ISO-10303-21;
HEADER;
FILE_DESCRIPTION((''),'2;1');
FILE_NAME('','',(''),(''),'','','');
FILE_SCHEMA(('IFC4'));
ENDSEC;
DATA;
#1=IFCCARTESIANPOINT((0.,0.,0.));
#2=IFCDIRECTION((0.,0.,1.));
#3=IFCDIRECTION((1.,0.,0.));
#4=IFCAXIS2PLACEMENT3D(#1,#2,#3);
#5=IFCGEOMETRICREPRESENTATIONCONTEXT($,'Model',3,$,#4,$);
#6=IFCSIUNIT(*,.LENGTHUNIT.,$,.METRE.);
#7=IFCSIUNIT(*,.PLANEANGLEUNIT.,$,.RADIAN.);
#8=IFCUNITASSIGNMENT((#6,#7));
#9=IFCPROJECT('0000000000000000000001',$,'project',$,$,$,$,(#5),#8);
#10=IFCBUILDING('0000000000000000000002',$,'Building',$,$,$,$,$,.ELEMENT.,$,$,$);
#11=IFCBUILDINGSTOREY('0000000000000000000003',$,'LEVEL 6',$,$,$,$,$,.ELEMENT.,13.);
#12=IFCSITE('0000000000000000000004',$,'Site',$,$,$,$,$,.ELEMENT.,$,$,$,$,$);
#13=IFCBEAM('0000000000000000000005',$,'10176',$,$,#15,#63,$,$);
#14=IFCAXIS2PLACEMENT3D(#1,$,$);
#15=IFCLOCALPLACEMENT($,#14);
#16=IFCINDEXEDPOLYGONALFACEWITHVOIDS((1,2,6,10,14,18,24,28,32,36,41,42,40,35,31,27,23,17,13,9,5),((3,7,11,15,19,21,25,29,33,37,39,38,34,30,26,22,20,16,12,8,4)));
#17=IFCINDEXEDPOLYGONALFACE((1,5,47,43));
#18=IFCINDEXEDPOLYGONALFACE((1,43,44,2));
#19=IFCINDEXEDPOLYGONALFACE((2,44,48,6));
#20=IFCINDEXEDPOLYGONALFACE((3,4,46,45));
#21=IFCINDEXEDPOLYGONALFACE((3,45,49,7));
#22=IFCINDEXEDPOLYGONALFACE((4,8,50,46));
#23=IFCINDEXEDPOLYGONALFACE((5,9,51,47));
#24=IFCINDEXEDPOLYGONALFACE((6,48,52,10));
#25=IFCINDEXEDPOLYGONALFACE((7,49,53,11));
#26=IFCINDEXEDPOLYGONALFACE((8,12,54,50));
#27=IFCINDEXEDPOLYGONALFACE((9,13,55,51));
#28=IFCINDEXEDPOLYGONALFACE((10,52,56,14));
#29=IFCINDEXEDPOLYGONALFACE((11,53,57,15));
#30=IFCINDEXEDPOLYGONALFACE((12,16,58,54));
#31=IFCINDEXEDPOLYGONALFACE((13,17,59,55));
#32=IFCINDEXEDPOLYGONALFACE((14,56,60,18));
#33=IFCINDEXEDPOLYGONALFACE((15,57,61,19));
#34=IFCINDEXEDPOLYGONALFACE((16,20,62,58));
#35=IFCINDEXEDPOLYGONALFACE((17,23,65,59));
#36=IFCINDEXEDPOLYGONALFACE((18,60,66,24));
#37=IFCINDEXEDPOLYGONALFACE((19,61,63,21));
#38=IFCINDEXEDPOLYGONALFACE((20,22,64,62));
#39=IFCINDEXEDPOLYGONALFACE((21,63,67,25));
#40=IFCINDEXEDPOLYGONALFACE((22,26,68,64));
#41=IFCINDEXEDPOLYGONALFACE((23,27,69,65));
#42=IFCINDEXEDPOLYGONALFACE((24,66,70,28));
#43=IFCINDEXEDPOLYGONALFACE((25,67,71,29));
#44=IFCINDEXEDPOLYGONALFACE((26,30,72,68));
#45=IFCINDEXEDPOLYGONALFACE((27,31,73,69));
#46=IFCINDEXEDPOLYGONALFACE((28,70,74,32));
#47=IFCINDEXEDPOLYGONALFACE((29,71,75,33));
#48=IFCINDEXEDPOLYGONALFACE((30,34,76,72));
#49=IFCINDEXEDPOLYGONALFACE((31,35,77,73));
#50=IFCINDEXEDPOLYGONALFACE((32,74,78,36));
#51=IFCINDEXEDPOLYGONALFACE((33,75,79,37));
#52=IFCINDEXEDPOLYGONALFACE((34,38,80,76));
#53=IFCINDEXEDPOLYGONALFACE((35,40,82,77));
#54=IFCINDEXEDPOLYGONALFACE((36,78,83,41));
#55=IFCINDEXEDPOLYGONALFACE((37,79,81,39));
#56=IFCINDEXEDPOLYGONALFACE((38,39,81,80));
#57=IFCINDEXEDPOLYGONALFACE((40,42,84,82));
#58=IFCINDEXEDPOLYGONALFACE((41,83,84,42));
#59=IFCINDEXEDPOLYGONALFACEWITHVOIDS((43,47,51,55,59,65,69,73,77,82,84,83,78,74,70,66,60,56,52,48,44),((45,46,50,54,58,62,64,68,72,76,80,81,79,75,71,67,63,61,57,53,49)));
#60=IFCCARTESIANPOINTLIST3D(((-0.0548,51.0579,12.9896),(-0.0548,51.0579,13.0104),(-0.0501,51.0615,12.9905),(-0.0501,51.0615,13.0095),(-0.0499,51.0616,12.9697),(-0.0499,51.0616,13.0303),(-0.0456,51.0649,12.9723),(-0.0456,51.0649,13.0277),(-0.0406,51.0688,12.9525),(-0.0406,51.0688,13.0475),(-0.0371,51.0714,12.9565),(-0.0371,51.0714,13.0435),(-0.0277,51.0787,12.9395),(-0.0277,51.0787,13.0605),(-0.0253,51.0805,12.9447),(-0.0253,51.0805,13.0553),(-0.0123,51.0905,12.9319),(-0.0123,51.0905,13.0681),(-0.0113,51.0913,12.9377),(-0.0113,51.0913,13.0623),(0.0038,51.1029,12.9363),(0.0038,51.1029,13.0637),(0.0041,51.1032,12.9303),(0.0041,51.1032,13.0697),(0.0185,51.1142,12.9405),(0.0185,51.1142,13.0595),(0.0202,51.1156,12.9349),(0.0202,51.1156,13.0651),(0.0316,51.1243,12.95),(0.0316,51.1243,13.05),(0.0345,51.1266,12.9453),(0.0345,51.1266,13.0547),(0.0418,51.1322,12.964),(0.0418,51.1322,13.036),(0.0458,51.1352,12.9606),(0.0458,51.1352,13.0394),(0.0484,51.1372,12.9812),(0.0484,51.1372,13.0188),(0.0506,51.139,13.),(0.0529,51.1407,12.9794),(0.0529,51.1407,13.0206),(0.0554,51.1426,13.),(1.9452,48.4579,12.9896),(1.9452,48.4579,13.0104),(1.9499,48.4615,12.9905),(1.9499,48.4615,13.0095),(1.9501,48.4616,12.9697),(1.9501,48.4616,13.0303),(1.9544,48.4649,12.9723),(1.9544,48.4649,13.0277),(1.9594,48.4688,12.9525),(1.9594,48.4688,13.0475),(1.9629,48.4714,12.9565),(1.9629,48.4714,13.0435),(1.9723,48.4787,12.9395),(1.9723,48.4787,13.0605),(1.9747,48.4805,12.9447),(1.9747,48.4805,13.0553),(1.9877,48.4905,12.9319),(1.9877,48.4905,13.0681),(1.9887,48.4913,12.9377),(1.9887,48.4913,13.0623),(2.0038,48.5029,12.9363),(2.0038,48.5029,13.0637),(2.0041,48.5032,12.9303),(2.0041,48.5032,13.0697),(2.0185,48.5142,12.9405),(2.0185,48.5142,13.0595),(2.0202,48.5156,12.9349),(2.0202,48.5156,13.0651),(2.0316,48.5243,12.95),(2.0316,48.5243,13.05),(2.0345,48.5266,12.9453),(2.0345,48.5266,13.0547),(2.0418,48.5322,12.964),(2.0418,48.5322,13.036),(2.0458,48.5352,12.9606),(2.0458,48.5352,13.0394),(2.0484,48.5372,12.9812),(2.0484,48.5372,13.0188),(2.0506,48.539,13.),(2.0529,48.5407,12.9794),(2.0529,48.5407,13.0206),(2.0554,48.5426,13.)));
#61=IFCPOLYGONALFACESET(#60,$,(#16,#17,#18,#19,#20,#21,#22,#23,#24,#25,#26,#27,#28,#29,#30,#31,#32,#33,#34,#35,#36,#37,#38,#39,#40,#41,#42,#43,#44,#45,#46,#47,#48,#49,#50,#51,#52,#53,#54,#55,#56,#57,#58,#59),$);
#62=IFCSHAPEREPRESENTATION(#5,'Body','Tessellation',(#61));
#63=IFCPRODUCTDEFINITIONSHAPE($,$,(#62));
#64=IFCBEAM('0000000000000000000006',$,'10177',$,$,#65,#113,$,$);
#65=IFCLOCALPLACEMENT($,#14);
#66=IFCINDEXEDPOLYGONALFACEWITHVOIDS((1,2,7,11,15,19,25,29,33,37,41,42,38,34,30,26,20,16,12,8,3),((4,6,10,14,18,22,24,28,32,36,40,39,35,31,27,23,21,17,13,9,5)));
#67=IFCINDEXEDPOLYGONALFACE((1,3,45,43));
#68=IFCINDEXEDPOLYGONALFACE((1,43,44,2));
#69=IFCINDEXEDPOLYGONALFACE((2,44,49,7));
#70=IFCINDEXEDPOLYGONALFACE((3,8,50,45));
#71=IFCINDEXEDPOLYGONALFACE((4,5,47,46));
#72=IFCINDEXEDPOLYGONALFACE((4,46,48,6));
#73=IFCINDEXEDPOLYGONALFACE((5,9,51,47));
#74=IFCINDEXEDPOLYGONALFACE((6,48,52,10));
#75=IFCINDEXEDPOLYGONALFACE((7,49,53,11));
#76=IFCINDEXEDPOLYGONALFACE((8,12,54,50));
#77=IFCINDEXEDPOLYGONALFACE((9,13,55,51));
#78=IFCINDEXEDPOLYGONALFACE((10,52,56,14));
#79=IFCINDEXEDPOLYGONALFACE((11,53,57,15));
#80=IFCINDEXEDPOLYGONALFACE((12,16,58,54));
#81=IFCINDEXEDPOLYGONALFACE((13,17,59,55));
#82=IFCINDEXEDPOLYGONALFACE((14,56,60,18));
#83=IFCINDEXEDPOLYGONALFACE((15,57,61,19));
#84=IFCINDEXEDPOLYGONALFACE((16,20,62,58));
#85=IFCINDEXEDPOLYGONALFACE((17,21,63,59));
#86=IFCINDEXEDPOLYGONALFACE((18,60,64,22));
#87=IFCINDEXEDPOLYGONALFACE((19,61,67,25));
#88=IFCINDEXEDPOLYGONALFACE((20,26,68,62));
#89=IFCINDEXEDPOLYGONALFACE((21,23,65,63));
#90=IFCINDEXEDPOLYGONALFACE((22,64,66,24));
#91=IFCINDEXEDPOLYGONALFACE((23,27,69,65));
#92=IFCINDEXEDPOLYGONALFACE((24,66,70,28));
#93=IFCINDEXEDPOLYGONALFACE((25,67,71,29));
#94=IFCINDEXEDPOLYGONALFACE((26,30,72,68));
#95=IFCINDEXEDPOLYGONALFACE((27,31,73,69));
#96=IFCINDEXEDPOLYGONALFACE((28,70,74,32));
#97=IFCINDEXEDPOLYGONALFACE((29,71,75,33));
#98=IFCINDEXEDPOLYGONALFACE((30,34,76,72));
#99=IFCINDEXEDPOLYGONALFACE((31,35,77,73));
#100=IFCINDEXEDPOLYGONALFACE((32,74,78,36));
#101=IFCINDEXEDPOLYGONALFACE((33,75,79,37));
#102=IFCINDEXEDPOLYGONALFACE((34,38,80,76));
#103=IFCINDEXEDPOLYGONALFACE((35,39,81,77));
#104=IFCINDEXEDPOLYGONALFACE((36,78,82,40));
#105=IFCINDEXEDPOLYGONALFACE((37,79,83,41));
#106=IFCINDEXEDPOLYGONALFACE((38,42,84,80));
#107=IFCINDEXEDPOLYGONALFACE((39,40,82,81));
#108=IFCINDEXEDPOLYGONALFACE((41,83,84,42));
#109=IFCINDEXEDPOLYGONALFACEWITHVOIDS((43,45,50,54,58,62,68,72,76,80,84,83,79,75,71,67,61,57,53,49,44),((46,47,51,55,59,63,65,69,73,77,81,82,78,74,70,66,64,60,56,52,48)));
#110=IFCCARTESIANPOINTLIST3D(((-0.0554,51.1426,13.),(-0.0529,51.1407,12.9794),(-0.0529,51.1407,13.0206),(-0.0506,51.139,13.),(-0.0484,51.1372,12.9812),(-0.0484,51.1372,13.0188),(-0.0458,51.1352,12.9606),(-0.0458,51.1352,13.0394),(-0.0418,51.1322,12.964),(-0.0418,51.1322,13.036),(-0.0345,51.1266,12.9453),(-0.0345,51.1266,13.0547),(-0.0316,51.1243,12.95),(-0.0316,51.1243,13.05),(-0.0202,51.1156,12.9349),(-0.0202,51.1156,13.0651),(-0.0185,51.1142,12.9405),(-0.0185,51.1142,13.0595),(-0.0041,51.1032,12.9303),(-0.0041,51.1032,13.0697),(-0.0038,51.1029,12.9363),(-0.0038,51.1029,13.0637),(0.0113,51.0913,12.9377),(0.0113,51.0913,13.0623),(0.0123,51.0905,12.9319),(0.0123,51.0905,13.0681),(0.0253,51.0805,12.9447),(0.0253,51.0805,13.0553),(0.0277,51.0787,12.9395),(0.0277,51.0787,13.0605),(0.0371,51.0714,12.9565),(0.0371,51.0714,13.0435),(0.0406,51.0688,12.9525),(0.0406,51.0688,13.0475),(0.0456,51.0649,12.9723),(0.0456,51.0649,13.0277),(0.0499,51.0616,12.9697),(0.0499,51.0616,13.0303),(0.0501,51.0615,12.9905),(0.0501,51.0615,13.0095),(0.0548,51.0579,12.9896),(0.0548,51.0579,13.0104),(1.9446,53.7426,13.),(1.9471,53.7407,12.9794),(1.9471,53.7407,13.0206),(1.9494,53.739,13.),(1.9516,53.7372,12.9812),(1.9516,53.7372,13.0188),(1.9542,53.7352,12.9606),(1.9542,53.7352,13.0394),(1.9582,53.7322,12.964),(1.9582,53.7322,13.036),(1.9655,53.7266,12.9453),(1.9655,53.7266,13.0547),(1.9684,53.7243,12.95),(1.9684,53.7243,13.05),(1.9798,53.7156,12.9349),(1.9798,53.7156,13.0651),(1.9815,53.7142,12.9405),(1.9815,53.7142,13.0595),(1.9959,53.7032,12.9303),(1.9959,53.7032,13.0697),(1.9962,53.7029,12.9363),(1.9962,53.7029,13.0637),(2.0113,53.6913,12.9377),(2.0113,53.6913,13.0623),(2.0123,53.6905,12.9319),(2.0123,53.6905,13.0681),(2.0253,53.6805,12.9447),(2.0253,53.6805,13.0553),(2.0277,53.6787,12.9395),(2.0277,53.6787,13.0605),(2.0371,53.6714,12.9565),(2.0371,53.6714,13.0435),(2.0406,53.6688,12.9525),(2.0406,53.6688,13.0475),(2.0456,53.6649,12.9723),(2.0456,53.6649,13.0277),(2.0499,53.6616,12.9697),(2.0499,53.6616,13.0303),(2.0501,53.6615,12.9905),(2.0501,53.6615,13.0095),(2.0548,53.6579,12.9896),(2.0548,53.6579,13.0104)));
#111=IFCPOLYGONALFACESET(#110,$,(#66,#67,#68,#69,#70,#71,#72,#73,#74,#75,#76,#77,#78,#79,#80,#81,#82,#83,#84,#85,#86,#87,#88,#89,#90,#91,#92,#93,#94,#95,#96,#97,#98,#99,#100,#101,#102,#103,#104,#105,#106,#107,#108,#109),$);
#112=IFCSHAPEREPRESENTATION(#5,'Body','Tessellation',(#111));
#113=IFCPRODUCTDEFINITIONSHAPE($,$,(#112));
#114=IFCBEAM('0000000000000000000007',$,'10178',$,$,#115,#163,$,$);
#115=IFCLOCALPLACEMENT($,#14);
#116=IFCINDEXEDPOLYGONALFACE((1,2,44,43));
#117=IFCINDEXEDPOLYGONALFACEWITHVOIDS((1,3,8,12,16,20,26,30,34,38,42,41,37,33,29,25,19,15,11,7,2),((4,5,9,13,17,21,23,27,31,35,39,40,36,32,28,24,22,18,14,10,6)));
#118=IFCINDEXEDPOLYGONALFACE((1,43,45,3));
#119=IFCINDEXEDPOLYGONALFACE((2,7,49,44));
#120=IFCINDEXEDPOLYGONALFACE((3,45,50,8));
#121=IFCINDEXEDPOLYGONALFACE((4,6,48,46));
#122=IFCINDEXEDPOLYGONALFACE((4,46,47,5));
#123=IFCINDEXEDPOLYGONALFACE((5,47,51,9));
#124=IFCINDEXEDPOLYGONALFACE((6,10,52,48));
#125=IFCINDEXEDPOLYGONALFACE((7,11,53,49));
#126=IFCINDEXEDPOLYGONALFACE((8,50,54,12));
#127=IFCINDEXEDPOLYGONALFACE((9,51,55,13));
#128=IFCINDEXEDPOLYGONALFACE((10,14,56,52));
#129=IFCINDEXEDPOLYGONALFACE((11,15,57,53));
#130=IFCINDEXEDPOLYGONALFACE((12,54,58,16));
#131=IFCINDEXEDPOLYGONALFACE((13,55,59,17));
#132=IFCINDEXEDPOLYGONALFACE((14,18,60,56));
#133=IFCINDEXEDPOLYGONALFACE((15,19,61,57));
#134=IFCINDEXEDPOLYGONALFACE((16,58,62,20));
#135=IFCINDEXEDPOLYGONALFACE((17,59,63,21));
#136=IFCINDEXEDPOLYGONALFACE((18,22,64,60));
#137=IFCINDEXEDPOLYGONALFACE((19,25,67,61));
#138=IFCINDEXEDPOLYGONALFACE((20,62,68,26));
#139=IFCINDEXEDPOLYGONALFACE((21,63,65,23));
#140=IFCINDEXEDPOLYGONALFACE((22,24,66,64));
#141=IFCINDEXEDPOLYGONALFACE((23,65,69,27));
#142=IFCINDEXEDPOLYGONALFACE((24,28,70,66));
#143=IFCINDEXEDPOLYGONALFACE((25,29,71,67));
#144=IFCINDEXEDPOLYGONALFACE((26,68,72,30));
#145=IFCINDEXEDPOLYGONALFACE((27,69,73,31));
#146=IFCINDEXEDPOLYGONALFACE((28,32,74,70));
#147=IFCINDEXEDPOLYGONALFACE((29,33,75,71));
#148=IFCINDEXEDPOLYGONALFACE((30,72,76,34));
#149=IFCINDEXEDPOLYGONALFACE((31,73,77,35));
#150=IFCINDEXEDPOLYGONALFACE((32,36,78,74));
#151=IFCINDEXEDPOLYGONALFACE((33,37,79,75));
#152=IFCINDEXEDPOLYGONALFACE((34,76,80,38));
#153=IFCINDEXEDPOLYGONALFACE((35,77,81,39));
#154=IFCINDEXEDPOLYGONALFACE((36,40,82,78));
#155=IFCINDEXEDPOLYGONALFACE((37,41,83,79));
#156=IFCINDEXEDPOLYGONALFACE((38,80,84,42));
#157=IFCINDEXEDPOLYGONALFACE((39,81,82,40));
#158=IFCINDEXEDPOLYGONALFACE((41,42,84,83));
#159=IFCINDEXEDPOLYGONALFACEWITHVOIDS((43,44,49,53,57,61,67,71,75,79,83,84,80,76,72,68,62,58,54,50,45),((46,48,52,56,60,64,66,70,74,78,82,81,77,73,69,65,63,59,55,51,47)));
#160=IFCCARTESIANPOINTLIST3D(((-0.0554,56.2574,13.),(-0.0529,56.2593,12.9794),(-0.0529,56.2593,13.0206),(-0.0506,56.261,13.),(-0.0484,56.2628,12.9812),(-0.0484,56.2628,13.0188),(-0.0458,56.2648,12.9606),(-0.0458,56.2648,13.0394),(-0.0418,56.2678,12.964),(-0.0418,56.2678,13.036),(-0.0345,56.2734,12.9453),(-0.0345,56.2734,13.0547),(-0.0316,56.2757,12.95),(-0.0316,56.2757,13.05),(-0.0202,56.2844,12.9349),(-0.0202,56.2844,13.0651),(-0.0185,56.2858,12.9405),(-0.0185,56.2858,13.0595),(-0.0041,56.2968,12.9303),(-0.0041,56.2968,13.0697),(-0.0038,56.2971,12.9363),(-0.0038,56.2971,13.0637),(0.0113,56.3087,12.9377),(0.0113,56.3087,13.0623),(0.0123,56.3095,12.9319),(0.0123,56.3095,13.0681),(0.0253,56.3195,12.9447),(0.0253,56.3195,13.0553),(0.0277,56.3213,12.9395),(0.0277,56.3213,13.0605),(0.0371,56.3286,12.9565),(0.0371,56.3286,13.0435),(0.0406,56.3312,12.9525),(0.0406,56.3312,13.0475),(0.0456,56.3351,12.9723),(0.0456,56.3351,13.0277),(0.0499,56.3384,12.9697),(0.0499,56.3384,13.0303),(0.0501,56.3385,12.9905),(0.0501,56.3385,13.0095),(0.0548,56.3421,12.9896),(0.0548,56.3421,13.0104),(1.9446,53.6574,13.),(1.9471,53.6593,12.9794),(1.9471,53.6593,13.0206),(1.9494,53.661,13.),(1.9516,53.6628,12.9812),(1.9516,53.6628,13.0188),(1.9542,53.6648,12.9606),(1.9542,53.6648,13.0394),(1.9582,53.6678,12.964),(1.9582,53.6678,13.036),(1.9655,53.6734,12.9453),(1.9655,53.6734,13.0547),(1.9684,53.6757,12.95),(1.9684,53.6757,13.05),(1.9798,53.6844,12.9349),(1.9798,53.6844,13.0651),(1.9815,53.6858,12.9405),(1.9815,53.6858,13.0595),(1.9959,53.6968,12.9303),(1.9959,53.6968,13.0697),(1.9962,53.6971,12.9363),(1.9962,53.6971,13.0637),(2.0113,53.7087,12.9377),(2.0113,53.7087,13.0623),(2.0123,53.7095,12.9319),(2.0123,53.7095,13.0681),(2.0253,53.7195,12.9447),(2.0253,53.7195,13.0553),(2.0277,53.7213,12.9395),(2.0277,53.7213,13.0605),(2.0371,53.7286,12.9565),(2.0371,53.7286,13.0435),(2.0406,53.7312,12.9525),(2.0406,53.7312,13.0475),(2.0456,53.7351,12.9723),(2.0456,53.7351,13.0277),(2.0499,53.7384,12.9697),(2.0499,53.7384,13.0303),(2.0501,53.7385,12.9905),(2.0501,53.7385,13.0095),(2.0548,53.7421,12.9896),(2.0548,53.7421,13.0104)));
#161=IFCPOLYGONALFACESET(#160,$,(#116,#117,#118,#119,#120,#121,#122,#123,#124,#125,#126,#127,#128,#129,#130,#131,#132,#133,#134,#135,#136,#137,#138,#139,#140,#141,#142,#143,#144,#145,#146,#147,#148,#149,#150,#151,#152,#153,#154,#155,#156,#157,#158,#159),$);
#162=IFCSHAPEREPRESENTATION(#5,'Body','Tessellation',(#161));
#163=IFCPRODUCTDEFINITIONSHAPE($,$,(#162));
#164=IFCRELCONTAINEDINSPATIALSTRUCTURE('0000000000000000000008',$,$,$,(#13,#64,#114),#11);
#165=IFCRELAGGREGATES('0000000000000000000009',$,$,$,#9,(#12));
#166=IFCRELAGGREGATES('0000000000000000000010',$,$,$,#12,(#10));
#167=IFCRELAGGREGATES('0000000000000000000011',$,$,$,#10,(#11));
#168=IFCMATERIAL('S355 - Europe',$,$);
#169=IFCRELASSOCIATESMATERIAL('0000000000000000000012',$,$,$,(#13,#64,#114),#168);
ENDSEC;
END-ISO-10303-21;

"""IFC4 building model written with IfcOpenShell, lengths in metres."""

from ifc_helpers import new_model, si_unit, frame, origin_with_axes, origin_2d_with_axis, place, context, project, spatial, hollow_circle, extrude, material, material_profile, profile_set, profile_usage, element, save


model = new_model("IFC4")

# Units and contexts
model_context = context("Model", 3, world=origin_with_axes())
ifc_project = project(units=[si_unit("LENGTHUNIT", "METRE"), si_unit("PLANEANGLEUNIT", "RADIAN")], contexts=[model_context])

# Site, building, storey
site = spatial("IfcSite", under=ifc_project, Name="Site", CompositionType="ELEMENT")
building = spatial("IfcBuilding", under=site, Name="Building", CompositionType="ELEMENT")
storey = spatial("IfcBuildingStorey", under=building, Name="LEVEL 6", CompositionType="ELEMENT", Elevation=13.0)

# Shared definitions
ifc_material = material(Name="S355 - Europe")

# Beams
ifc_material_profile_1 = material_profile(ifc_material, hollow_circle(Radius=0.0699, WallThickness=0.006, at=origin_2d_with_axis()))
ifc_profile_set_1 = profile_set([ifc_material_profile_1])
ifc_profile_usage_1 = profile_usage(ifc_profile_set_1, cardinal=10)
beam_1_placement = place(None, frame((0.0, 51.1, 13.0), z_axis=(0.609711, -0.792624, 0.0), x_axis=(0.792624, 0.609711, 0.0)))
element("IfcBeam", 1, at=beam_1_placement, inside=storey, material=ifc_profile_usage_1, Name="10176", context=model_context, shape_type="SweptSolid", body=[
    extrude(hollow_circle(Radius=0.0699, WallThickness=0.006, at=origin_2d_with_axis()), origin_with_axes(), (0.0, 0.0, 1.0), 3.2802),
])
ifc_material_profile_2 = material_profile(ifc_material, hollow_circle(Radius=0.0699, WallThickness=0.006, at=origin_2d_with_axis()))
ifc_profile_set_2 = profile_set([ifc_material_profile_2])
ifc_profile_usage_2 = profile_usage(ifc_profile_set_2, cardinal=10)
beam_2_placement = place(None, frame((0.0, 51.1, 13.0), z_axis=(0.609711, 0.792624, 0.0), x_axis=(-0.792624, 0.609711, 0.0)))
element("IfcBeam", 2, at=beam_2_placement, inside=storey, material=ifc_profile_usage_2, Name="10177", context=model_context, shape_type="SweptSolid", body=[
    extrude(hollow_circle(Radius=0.0699, WallThickness=0.006, at=origin_2d_with_axis()), origin_with_axes(), (0.0, 0.0, 1.0), 3.2802),
])
ifc_material_profile_3 = material_profile(ifc_material, hollow_circle(Radius=0.0699, WallThickness=0.006, at=origin_2d_with_axis()))
ifc_profile_set_3 = profile_set([ifc_material_profile_3])
ifc_profile_usage_3 = profile_usage(ifc_profile_set_3, cardinal=10)
beam_3_placement = place(None, frame((2.0, 53.7, 13.0), z_axis=(-0.609711, 0.792624, 0.0), x_axis=(-0.792624, -0.609711, 0.0)))
element("IfcBeam", 3, at=beam_3_placement, inside=storey, material=ifc_profile_usage_3, Name="10178", context=model_context, shape_type="SweptSolid", body=[
    extrude(hollow_circle(Radius=0.0699, WallThickness=0.006, at=origin_2d_with_axis()), origin_with_axes(), (0.0, 0.0, 1.0), 3.2802),
])

save(model, "model.ifc")
